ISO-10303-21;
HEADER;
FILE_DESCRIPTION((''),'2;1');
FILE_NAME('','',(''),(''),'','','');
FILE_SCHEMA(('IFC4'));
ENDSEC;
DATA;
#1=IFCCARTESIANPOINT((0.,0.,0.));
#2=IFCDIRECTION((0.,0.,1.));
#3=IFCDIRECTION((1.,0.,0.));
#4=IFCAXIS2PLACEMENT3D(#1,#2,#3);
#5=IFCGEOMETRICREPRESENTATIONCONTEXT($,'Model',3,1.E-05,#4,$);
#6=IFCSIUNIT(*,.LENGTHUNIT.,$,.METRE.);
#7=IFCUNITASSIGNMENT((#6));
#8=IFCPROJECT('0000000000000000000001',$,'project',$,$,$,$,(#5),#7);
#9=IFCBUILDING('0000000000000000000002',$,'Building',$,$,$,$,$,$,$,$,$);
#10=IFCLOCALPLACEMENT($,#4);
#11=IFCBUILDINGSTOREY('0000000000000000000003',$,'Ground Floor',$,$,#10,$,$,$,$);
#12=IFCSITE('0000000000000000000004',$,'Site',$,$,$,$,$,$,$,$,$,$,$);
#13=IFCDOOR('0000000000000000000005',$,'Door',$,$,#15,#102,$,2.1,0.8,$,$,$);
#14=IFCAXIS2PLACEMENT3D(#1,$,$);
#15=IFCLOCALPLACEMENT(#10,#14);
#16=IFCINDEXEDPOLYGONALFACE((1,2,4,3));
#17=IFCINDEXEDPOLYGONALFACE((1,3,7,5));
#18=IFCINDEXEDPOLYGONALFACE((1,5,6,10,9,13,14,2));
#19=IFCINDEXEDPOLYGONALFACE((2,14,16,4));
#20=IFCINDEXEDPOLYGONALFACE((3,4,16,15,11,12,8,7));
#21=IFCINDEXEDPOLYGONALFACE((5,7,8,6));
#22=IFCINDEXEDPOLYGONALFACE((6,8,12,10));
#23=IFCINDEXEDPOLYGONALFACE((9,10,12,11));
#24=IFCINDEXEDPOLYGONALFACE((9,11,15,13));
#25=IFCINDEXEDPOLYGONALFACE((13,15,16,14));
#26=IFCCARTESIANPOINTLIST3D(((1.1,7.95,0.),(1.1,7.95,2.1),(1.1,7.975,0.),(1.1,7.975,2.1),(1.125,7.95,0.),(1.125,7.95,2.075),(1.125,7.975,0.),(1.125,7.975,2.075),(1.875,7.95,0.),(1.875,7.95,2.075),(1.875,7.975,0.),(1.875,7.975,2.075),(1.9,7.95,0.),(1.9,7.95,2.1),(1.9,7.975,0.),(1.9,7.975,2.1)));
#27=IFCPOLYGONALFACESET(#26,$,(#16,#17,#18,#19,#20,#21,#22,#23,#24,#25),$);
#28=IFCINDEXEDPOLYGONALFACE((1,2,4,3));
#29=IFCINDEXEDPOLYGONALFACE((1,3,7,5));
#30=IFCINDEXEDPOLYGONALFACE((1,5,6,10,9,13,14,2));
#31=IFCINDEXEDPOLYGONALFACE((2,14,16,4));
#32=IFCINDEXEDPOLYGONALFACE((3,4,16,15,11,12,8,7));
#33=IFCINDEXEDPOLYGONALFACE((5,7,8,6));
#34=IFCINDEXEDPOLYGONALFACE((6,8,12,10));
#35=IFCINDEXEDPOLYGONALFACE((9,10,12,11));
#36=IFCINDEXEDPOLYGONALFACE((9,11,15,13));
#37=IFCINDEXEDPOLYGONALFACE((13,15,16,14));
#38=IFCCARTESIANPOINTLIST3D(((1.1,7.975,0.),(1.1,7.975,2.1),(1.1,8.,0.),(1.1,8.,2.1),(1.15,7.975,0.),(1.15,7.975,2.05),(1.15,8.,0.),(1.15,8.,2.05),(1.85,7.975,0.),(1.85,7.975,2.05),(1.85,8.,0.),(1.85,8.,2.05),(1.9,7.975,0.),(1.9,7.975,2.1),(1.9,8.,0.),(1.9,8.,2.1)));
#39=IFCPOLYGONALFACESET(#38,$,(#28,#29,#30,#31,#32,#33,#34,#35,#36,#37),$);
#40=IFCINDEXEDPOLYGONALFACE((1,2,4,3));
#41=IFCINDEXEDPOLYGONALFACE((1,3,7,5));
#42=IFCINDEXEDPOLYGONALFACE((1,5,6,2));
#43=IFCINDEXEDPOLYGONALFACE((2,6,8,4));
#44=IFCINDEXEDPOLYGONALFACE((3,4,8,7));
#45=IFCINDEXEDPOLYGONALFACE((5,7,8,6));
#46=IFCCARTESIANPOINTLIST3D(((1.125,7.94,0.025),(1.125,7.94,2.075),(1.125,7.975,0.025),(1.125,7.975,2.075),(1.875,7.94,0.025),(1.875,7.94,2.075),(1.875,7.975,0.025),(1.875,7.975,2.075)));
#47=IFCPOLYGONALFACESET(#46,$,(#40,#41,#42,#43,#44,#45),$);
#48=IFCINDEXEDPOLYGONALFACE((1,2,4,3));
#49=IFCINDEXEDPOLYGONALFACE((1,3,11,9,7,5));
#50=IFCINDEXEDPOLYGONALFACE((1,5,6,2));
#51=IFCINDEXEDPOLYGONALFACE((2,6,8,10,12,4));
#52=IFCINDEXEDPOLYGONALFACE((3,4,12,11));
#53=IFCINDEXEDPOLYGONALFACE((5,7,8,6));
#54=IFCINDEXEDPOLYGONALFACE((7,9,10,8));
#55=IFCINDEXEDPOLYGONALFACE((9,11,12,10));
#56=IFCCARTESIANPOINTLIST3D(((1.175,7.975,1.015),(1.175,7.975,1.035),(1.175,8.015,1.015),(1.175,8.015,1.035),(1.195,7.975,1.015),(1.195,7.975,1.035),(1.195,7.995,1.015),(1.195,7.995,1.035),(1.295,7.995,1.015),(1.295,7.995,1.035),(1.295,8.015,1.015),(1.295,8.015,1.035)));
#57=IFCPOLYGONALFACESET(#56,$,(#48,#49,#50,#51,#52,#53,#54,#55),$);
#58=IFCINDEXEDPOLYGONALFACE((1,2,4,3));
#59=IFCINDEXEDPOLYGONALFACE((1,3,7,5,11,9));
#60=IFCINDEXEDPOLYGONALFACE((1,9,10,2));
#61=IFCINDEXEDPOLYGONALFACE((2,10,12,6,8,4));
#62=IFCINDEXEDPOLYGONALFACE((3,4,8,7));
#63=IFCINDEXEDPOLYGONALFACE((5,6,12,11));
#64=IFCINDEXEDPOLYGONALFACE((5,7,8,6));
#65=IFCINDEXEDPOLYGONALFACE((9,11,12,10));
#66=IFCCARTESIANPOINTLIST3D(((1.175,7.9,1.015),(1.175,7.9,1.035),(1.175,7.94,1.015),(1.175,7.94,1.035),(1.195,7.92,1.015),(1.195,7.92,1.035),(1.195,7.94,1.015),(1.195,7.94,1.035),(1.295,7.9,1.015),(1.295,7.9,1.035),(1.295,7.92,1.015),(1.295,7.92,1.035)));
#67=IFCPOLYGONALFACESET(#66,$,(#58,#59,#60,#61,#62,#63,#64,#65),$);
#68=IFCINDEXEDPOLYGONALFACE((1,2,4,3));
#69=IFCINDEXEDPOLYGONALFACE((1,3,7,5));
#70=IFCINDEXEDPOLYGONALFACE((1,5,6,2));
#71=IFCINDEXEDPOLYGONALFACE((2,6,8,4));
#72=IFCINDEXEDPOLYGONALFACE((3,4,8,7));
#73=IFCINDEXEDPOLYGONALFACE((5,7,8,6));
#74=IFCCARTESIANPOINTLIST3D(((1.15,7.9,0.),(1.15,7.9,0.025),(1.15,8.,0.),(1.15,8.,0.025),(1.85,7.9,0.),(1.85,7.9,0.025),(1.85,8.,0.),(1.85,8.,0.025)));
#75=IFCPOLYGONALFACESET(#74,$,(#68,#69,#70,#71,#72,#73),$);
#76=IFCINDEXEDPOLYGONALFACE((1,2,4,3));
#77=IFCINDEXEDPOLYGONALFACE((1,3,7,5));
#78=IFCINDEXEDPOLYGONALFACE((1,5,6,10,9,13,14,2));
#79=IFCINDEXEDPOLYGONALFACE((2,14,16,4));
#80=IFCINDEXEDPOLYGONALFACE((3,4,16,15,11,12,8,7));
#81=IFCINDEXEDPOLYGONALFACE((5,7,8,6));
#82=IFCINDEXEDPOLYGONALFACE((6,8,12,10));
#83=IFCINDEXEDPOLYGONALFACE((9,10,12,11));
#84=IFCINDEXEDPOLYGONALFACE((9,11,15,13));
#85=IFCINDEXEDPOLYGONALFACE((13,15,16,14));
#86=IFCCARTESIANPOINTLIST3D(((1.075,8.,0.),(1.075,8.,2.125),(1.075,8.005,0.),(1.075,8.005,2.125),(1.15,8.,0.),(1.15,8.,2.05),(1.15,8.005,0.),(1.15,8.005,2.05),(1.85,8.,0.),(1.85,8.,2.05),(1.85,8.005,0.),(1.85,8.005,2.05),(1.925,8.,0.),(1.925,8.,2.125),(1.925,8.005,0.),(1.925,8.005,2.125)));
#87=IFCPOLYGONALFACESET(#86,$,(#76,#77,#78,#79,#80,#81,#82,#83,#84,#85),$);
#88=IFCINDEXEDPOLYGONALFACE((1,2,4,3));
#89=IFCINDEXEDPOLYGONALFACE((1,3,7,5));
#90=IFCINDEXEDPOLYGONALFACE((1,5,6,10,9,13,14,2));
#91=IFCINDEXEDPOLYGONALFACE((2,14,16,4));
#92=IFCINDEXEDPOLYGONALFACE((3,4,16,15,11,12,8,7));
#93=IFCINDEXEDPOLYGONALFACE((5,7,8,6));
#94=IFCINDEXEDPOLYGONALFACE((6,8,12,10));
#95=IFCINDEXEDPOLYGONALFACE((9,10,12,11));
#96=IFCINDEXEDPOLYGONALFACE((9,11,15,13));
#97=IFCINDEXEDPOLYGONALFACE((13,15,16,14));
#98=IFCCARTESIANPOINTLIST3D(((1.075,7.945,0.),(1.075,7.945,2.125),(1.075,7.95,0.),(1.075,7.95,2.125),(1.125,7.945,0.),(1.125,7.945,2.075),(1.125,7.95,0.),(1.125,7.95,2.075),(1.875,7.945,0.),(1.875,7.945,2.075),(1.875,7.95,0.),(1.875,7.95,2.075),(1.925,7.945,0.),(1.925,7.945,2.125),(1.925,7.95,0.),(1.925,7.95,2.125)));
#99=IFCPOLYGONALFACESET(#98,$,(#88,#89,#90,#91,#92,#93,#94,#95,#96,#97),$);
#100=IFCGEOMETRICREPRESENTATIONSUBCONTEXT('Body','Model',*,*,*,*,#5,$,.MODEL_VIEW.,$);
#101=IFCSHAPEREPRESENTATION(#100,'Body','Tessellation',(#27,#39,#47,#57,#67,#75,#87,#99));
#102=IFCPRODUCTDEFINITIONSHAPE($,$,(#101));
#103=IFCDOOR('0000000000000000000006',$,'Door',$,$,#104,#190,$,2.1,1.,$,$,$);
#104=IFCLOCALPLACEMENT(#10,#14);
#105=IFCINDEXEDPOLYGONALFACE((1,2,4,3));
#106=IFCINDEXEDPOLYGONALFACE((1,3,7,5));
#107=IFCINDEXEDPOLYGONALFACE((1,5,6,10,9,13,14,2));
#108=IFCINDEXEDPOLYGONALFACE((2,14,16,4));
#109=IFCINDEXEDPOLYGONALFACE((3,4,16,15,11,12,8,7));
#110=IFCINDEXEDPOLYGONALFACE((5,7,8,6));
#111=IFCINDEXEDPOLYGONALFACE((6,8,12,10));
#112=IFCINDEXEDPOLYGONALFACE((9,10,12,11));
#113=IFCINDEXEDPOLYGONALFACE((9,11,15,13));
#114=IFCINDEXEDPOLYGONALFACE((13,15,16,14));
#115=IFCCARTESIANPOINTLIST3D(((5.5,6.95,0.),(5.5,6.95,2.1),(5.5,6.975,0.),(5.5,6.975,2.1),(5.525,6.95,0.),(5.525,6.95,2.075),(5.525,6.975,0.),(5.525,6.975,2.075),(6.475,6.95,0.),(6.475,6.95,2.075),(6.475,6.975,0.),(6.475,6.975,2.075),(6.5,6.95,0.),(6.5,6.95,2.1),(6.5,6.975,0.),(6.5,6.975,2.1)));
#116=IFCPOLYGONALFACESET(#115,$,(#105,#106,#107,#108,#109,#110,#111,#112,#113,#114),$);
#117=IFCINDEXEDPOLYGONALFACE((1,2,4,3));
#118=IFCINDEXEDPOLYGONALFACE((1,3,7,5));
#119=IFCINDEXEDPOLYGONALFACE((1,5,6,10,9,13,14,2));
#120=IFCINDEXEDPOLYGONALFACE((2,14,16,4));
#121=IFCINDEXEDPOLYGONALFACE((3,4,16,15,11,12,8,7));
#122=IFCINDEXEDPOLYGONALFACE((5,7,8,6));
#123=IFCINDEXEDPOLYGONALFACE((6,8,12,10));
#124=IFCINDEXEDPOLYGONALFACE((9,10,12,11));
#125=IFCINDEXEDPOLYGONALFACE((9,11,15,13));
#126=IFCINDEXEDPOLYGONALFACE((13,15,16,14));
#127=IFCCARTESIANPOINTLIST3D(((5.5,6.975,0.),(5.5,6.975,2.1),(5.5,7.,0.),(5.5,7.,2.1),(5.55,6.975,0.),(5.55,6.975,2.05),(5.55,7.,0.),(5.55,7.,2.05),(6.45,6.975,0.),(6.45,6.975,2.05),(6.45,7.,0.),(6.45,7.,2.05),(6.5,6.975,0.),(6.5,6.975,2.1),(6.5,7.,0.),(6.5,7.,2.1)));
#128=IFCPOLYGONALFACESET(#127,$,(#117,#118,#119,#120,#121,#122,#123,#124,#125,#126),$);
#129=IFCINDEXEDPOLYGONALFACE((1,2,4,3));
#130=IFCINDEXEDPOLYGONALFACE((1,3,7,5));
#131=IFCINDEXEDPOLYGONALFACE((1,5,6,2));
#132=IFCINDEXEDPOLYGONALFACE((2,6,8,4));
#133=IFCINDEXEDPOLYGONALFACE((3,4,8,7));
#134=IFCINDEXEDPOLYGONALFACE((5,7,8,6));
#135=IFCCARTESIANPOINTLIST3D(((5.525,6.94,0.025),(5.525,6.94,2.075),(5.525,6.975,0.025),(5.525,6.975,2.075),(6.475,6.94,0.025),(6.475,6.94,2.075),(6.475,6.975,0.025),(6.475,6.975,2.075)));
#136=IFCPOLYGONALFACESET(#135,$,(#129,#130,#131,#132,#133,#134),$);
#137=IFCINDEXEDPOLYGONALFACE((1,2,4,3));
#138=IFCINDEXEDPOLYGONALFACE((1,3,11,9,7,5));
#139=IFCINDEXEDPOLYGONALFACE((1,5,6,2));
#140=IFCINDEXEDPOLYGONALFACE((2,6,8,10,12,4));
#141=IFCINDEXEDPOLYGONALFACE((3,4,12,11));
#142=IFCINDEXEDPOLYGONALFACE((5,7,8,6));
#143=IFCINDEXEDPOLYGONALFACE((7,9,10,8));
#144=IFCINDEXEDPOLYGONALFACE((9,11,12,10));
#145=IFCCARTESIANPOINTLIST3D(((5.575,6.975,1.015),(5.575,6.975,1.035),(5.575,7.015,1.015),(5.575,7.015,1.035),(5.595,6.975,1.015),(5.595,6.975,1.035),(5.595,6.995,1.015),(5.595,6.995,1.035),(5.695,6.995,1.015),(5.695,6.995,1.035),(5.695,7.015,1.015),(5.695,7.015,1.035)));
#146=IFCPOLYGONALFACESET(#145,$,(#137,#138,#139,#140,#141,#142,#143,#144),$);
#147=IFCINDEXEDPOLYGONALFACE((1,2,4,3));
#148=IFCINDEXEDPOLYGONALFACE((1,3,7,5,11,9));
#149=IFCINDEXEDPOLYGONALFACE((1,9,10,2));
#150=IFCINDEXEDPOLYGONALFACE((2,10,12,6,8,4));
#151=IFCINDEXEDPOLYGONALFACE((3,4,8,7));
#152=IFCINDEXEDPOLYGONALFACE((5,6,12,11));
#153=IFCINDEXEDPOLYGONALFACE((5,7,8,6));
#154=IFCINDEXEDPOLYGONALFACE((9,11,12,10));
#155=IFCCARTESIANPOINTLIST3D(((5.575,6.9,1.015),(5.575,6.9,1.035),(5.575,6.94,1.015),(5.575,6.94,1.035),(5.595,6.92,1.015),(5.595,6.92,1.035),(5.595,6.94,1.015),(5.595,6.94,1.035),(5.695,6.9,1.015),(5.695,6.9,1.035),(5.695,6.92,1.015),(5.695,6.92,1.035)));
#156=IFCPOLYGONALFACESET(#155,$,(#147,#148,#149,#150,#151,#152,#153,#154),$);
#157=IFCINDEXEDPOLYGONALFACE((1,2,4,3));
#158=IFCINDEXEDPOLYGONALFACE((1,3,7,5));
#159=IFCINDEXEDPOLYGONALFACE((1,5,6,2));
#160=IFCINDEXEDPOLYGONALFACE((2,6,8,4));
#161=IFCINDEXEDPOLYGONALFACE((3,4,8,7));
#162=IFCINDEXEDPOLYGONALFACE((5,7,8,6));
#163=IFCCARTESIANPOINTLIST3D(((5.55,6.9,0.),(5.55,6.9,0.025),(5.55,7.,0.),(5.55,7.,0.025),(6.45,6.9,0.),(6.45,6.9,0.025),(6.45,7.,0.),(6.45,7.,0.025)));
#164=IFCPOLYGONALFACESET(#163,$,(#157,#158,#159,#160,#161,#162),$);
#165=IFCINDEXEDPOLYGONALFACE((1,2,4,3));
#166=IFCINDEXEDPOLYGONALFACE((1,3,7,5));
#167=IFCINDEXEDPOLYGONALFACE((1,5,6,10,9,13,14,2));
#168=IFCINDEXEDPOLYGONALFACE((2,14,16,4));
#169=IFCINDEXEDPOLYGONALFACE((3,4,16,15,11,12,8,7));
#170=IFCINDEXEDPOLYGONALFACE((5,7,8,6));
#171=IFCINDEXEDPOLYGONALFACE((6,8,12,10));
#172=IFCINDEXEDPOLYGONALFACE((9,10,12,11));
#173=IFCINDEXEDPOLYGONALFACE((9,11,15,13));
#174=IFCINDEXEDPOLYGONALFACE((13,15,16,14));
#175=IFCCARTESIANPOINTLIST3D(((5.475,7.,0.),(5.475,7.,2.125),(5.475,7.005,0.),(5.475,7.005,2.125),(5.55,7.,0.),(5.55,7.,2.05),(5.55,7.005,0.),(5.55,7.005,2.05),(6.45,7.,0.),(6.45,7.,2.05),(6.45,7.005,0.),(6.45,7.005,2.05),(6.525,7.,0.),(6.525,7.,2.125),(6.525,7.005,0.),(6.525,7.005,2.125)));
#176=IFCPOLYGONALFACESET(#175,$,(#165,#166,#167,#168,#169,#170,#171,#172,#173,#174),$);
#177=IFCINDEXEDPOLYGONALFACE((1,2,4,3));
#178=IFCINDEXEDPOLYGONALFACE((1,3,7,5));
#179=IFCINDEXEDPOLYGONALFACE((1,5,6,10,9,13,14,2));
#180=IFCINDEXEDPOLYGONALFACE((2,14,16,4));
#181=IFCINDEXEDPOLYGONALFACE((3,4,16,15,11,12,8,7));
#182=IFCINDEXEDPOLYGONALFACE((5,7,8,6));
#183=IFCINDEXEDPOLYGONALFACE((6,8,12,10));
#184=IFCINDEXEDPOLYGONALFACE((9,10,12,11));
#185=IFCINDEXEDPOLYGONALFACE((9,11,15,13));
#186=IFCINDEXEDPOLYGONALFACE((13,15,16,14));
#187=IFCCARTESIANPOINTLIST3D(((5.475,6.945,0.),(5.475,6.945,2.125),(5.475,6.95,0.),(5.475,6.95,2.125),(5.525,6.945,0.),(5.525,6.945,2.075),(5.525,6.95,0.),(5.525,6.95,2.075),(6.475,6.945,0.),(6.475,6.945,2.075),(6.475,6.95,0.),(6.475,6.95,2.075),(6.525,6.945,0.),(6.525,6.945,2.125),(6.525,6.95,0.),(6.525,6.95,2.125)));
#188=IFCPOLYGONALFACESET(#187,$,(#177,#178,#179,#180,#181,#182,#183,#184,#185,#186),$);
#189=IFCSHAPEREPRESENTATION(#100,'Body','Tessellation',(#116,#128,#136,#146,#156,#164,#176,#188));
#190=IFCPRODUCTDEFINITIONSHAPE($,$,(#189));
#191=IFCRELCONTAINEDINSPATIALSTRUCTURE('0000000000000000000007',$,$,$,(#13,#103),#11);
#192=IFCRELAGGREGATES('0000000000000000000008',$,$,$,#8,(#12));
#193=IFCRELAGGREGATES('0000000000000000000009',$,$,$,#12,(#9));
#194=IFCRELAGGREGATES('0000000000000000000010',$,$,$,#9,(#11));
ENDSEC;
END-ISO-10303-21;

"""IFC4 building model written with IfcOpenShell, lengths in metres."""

from ifc_helpers import new_model, si_unit, frame, origin_with_axes, place, context, subcontext, project, spatial, line, indexed_curve, outline, extrude, element, save


model = new_model("IFC4")

# Units and contexts
model_context = context("Model", 3, precision=1e-05, world=origin_with_axes())
body_context = subcontext(model_context, "Body", "Model", "MODEL_VIEW")
ifc_project = project(units=[si_unit("LENGTHUNIT", "METRE")], contexts=[model_context])

# Site, building, storey
site = spatial("IfcSite", under=ifc_project, Name="Site")
building = spatial("IfcBuilding", under=site, Name="Building")
storey_placement = place(None, origin_with_axes())
storey = spatial("IfcBuildingStorey", under=building, at=storey_placement, Name="Ground Floor")

# Doors
door_1_placement = place(storey_placement, frame((1.9, 8.0, 0.0), z_axis=(0.0, 0.0, 1.0), x_axis=(-1.0, 0.0, 0.0)))
element("IfcDoor", 1, at=door_1_placement, inside=storey, Name="Door", OverallHeight=2.1, OverallWidth=0.8, context=body_context, shape_type="SweptSolid", body=[
    extrude(outline(indexed_curve([(0.0, 0.0), (0.0, 2.1), (0.8, 2.1), (0.8, 0.0), (0.775, 0.0), (0.775, 2.075), (0.025, 2.075), (0.025, 0.0)], segments=[line(1, 2, 3, 4, 5, 6, 7, 8, 1)])), frame((0.0, 0.025, 0.0), z_axis=(0.0, -1.0, 0.0), x_axis=(1.0, 0.0, 0.0)), (0.0, 0.0, -1.0), 0.025),
    extrude(outline(indexed_curve([(0.0, 0.0), (0.0, 2.1), (0.8, 2.1), (0.8, 0.0), (0.75, 0.0), (0.75, 2.05), (0.05, 2.05), (0.05, 0.0)], segments=[line(1, 2, 3, 4, 5, 6, 7, 8, 1)])), frame((0.0, 0.0, 0.0), z_axis=(0.0, -1.0, 0.0), x_axis=(1.0, 0.0, 0.0)), (0.0, 0.0, -1.0), 0.025),
    extrude(outline(indexed_curve([(0.0, 0.0), (0.75, 0.0), (0.75, 0.035), (0.0, 0.035)], segments=[line(1, 2, 3, 4, 1)])), frame((0.025, 0.025, 0.025), z_axis=(0.0, 0.0, 1.0), x_axis=(1.0, 0.0, 0.0)), (0.0, 0.0, 1.0), 2.05),
    extrude(outline(indexed_curve([(0.0, 0.0), (0.0, -0.04), (-0.12, -0.04), (-0.12, -0.02), (-0.02, -0.02), (-0.02, 0.0)], segments=[line(1, 2, 3, 4, 5, 6, 1)])), frame((0.725, 0.025, 1.015), z_axis=(0.0, 0.0, 1.0), x_axis=(1.0, 0.0, 0.0)), (0.0, 0.0, 1.0), 0.02),
    extrude(outline(indexed_curve([(0.0, 0.0), (0.0, 0.04), (-0.12, 0.04), (-0.12, 0.02), (-0.02, 0.02), (-0.02, 0.0)], segments=[line(1, 2, 3, 4, 5, 6, 1)])), frame((0.725, 0.06, 1.015), z_axis=(0.0, 0.0, 1.0), x_axis=(1.0, 0.0, 0.0)), (0.0, 0.0, 1.0), 0.02),
    extrude(outline(indexed_curve([(0.0, 0.0), (0.7, 0.0), (0.7, 0.1), (0.0, 0.1)], segments=[line(1, 2, 3, 4, 1)])), frame((0.05, 0.0, 0.0), z_axis=(0.0, 0.0, 1.0), x_axis=(1.0, 0.0, 0.0)), (0.0, 0.0, 1.0), 0.025),
    extrude(outline(indexed_curve([(0.0, 0.0), (0.0, 2.125), (0.85, 2.125), (0.85, 0.0), (0.775, 0.0), (0.775, 2.05), (0.075, 2.05), (0.075, 0.0)], segments=[line(1, 2, 3, 4, 5, 6, 7, 8, 1)])), frame((-0.025, -0.005, 0.0), z_axis=(0.0, -1.0, 0.0), x_axis=(1.0, 0.0, 0.0)), (0.0, 0.0, -1.0), 0.005),
    extrude(outline(indexed_curve([(0.0, 0.0), (0.0, 2.125), (0.85, 2.125), (0.85, 0.0), (0.8, 0.0), (0.8, 2.075), (0.05, 2.075), (0.05, 0.0)], segments=[line(1, 2, 3, 4, 5, 6, 7, 8, 1)])), frame((-0.025, 0.05, 0.0), z_axis=(0.0, -1.0, 0.0), x_axis=(1.0, 0.0, 0.0)), (0.0, 0.0, -1.0), 0.005),
])
door_2_placement = place(storey_placement, frame((6.5, 7.0, 0.0), z_axis=(0.0, 0.0, 1.0), x_axis=(-1.0, 0.0, 0.0)))
element("IfcDoor", 2, at=door_2_placement, inside=storey, Name="Door", OverallHeight=2.1, OverallWidth=1.0, context=body_context, shape_type="SweptSolid", body=[
    extrude(outline(indexed_curve([(0.0, 0.0), (0.0, 2.1), (1.0, 2.1), (1.0, 0.0), (0.975, 0.0), (0.975, 2.075), (0.025, 2.075), (0.025, 0.0)], segments=[line(1, 2, 3, 4, 5, 6, 7, 8, 1)])), frame((0.0, 0.025, 0.0), z_axis=(0.0, -1.0, 0.0), x_axis=(1.0, 0.0, 0.0)), (0.0, 0.0, -1.0), 0.025),
    extrude(outline(indexed_curve([(0.0, 0.0), (0.0, 2.1), (1.0, 2.1), (1.0, 0.0), (0.95, 0.0), (0.95, 2.05), (0.05, 2.05), (0.05, 0.0)], segments=[line(1, 2, 3, 4, 5, 6, 7, 8, 1)])), frame((0.0, 0.0, 0.0), z_axis=(0.0, -1.0, 0.0), x_axis=(1.0, 0.0, 0.0)), (0.0, 0.0, -1.0), 0.025),
    extrude(outline(indexed_curve([(0.0, 0.0), (0.95, 0.0), (0.95, 0.035), (0.0, 0.035)], segments=[line(1, 2, 3, 4, 1)])), frame((0.025, 0.025, 0.025), z_axis=(0.0, 0.0, 1.0), x_axis=(1.0, 0.0, 0.0)), (0.0, 0.0, 1.0), 2.05),
    extrude(outline(indexed_curve([(0.0, 0.0), (0.0, -0.04), (-0.12, -0.04), (-0.12, -0.02), (-0.02, -0.02), (-0.02, 0.0)], segments=[line(1, 2, 3, 4, 5, 6, 1)])), frame((0.925, 0.025, 1.015), z_axis=(0.0, 0.0, 1.0), x_axis=(1.0, 0.0, 0.0)), (0.0, 0.0, 1.0), 0.02),
    extrude(outline(indexed_curve([(0.0, 0.0), (0.0, 0.04), (-0.12, 0.04), (-0.12, 0.02), (-0.02, 0.02), (-0.02, 0.0)], segments=[line(1, 2, 3, 4, 5, 6, 1)])), frame((0.925, 0.06, 1.015), z_axis=(0.0, 0.0, 1.0), x_axis=(1.0, 0.0, 0.0)), (0.0, 0.0, 1.0), 0.02),
    extrude(outline(indexed_curve([(0.0, 0.0), (0.9, 0.0), (0.9, 0.1), (0.0, 0.1)], segments=[line(1, 2, 3, 4, 1)])), frame((0.05, 0.0, 0.0), z_axis=(0.0, 0.0, 1.0), x_axis=(1.0, 0.0, 0.0)), (0.0, 0.0, 1.0), 0.025),
    extrude(outline(indexed_curve([(0.0, 0.0), (0.0, 2.125), (1.05, 2.125), (1.05, 0.0), (0.975, 0.0), (0.975, 2.05), (0.075, 2.05), (0.075, 0.0)], segments=[line(1, 2, 3, 4, 5, 6, 7, 8, 1)])), frame((-0.025, -0.005, 0.0), z_axis=(0.0, -1.0, 0.0), x_axis=(1.0, 0.0, 0.0)), (0.0, 0.0, -1.0), 0.005),
    extrude(outline(indexed_curve([(0.0, 0.0), (0.0, 2.125), (1.05, 2.125), (1.05, 0.0), (1.0, 0.0), (1.0, 2.075), (0.05, 2.075), (0.05, 0.0)], segments=[line(1, 2, 3, 4, 5, 6, 7, 8, 1)])), frame((-0.025, 0.05, 0.0), z_axis=(0.0, -1.0, 0.0), x_axis=(1.0, 0.0, 0.0)), (0.0, 0.0, -1.0), 0.005),
])

save(model, "model.ifc")
